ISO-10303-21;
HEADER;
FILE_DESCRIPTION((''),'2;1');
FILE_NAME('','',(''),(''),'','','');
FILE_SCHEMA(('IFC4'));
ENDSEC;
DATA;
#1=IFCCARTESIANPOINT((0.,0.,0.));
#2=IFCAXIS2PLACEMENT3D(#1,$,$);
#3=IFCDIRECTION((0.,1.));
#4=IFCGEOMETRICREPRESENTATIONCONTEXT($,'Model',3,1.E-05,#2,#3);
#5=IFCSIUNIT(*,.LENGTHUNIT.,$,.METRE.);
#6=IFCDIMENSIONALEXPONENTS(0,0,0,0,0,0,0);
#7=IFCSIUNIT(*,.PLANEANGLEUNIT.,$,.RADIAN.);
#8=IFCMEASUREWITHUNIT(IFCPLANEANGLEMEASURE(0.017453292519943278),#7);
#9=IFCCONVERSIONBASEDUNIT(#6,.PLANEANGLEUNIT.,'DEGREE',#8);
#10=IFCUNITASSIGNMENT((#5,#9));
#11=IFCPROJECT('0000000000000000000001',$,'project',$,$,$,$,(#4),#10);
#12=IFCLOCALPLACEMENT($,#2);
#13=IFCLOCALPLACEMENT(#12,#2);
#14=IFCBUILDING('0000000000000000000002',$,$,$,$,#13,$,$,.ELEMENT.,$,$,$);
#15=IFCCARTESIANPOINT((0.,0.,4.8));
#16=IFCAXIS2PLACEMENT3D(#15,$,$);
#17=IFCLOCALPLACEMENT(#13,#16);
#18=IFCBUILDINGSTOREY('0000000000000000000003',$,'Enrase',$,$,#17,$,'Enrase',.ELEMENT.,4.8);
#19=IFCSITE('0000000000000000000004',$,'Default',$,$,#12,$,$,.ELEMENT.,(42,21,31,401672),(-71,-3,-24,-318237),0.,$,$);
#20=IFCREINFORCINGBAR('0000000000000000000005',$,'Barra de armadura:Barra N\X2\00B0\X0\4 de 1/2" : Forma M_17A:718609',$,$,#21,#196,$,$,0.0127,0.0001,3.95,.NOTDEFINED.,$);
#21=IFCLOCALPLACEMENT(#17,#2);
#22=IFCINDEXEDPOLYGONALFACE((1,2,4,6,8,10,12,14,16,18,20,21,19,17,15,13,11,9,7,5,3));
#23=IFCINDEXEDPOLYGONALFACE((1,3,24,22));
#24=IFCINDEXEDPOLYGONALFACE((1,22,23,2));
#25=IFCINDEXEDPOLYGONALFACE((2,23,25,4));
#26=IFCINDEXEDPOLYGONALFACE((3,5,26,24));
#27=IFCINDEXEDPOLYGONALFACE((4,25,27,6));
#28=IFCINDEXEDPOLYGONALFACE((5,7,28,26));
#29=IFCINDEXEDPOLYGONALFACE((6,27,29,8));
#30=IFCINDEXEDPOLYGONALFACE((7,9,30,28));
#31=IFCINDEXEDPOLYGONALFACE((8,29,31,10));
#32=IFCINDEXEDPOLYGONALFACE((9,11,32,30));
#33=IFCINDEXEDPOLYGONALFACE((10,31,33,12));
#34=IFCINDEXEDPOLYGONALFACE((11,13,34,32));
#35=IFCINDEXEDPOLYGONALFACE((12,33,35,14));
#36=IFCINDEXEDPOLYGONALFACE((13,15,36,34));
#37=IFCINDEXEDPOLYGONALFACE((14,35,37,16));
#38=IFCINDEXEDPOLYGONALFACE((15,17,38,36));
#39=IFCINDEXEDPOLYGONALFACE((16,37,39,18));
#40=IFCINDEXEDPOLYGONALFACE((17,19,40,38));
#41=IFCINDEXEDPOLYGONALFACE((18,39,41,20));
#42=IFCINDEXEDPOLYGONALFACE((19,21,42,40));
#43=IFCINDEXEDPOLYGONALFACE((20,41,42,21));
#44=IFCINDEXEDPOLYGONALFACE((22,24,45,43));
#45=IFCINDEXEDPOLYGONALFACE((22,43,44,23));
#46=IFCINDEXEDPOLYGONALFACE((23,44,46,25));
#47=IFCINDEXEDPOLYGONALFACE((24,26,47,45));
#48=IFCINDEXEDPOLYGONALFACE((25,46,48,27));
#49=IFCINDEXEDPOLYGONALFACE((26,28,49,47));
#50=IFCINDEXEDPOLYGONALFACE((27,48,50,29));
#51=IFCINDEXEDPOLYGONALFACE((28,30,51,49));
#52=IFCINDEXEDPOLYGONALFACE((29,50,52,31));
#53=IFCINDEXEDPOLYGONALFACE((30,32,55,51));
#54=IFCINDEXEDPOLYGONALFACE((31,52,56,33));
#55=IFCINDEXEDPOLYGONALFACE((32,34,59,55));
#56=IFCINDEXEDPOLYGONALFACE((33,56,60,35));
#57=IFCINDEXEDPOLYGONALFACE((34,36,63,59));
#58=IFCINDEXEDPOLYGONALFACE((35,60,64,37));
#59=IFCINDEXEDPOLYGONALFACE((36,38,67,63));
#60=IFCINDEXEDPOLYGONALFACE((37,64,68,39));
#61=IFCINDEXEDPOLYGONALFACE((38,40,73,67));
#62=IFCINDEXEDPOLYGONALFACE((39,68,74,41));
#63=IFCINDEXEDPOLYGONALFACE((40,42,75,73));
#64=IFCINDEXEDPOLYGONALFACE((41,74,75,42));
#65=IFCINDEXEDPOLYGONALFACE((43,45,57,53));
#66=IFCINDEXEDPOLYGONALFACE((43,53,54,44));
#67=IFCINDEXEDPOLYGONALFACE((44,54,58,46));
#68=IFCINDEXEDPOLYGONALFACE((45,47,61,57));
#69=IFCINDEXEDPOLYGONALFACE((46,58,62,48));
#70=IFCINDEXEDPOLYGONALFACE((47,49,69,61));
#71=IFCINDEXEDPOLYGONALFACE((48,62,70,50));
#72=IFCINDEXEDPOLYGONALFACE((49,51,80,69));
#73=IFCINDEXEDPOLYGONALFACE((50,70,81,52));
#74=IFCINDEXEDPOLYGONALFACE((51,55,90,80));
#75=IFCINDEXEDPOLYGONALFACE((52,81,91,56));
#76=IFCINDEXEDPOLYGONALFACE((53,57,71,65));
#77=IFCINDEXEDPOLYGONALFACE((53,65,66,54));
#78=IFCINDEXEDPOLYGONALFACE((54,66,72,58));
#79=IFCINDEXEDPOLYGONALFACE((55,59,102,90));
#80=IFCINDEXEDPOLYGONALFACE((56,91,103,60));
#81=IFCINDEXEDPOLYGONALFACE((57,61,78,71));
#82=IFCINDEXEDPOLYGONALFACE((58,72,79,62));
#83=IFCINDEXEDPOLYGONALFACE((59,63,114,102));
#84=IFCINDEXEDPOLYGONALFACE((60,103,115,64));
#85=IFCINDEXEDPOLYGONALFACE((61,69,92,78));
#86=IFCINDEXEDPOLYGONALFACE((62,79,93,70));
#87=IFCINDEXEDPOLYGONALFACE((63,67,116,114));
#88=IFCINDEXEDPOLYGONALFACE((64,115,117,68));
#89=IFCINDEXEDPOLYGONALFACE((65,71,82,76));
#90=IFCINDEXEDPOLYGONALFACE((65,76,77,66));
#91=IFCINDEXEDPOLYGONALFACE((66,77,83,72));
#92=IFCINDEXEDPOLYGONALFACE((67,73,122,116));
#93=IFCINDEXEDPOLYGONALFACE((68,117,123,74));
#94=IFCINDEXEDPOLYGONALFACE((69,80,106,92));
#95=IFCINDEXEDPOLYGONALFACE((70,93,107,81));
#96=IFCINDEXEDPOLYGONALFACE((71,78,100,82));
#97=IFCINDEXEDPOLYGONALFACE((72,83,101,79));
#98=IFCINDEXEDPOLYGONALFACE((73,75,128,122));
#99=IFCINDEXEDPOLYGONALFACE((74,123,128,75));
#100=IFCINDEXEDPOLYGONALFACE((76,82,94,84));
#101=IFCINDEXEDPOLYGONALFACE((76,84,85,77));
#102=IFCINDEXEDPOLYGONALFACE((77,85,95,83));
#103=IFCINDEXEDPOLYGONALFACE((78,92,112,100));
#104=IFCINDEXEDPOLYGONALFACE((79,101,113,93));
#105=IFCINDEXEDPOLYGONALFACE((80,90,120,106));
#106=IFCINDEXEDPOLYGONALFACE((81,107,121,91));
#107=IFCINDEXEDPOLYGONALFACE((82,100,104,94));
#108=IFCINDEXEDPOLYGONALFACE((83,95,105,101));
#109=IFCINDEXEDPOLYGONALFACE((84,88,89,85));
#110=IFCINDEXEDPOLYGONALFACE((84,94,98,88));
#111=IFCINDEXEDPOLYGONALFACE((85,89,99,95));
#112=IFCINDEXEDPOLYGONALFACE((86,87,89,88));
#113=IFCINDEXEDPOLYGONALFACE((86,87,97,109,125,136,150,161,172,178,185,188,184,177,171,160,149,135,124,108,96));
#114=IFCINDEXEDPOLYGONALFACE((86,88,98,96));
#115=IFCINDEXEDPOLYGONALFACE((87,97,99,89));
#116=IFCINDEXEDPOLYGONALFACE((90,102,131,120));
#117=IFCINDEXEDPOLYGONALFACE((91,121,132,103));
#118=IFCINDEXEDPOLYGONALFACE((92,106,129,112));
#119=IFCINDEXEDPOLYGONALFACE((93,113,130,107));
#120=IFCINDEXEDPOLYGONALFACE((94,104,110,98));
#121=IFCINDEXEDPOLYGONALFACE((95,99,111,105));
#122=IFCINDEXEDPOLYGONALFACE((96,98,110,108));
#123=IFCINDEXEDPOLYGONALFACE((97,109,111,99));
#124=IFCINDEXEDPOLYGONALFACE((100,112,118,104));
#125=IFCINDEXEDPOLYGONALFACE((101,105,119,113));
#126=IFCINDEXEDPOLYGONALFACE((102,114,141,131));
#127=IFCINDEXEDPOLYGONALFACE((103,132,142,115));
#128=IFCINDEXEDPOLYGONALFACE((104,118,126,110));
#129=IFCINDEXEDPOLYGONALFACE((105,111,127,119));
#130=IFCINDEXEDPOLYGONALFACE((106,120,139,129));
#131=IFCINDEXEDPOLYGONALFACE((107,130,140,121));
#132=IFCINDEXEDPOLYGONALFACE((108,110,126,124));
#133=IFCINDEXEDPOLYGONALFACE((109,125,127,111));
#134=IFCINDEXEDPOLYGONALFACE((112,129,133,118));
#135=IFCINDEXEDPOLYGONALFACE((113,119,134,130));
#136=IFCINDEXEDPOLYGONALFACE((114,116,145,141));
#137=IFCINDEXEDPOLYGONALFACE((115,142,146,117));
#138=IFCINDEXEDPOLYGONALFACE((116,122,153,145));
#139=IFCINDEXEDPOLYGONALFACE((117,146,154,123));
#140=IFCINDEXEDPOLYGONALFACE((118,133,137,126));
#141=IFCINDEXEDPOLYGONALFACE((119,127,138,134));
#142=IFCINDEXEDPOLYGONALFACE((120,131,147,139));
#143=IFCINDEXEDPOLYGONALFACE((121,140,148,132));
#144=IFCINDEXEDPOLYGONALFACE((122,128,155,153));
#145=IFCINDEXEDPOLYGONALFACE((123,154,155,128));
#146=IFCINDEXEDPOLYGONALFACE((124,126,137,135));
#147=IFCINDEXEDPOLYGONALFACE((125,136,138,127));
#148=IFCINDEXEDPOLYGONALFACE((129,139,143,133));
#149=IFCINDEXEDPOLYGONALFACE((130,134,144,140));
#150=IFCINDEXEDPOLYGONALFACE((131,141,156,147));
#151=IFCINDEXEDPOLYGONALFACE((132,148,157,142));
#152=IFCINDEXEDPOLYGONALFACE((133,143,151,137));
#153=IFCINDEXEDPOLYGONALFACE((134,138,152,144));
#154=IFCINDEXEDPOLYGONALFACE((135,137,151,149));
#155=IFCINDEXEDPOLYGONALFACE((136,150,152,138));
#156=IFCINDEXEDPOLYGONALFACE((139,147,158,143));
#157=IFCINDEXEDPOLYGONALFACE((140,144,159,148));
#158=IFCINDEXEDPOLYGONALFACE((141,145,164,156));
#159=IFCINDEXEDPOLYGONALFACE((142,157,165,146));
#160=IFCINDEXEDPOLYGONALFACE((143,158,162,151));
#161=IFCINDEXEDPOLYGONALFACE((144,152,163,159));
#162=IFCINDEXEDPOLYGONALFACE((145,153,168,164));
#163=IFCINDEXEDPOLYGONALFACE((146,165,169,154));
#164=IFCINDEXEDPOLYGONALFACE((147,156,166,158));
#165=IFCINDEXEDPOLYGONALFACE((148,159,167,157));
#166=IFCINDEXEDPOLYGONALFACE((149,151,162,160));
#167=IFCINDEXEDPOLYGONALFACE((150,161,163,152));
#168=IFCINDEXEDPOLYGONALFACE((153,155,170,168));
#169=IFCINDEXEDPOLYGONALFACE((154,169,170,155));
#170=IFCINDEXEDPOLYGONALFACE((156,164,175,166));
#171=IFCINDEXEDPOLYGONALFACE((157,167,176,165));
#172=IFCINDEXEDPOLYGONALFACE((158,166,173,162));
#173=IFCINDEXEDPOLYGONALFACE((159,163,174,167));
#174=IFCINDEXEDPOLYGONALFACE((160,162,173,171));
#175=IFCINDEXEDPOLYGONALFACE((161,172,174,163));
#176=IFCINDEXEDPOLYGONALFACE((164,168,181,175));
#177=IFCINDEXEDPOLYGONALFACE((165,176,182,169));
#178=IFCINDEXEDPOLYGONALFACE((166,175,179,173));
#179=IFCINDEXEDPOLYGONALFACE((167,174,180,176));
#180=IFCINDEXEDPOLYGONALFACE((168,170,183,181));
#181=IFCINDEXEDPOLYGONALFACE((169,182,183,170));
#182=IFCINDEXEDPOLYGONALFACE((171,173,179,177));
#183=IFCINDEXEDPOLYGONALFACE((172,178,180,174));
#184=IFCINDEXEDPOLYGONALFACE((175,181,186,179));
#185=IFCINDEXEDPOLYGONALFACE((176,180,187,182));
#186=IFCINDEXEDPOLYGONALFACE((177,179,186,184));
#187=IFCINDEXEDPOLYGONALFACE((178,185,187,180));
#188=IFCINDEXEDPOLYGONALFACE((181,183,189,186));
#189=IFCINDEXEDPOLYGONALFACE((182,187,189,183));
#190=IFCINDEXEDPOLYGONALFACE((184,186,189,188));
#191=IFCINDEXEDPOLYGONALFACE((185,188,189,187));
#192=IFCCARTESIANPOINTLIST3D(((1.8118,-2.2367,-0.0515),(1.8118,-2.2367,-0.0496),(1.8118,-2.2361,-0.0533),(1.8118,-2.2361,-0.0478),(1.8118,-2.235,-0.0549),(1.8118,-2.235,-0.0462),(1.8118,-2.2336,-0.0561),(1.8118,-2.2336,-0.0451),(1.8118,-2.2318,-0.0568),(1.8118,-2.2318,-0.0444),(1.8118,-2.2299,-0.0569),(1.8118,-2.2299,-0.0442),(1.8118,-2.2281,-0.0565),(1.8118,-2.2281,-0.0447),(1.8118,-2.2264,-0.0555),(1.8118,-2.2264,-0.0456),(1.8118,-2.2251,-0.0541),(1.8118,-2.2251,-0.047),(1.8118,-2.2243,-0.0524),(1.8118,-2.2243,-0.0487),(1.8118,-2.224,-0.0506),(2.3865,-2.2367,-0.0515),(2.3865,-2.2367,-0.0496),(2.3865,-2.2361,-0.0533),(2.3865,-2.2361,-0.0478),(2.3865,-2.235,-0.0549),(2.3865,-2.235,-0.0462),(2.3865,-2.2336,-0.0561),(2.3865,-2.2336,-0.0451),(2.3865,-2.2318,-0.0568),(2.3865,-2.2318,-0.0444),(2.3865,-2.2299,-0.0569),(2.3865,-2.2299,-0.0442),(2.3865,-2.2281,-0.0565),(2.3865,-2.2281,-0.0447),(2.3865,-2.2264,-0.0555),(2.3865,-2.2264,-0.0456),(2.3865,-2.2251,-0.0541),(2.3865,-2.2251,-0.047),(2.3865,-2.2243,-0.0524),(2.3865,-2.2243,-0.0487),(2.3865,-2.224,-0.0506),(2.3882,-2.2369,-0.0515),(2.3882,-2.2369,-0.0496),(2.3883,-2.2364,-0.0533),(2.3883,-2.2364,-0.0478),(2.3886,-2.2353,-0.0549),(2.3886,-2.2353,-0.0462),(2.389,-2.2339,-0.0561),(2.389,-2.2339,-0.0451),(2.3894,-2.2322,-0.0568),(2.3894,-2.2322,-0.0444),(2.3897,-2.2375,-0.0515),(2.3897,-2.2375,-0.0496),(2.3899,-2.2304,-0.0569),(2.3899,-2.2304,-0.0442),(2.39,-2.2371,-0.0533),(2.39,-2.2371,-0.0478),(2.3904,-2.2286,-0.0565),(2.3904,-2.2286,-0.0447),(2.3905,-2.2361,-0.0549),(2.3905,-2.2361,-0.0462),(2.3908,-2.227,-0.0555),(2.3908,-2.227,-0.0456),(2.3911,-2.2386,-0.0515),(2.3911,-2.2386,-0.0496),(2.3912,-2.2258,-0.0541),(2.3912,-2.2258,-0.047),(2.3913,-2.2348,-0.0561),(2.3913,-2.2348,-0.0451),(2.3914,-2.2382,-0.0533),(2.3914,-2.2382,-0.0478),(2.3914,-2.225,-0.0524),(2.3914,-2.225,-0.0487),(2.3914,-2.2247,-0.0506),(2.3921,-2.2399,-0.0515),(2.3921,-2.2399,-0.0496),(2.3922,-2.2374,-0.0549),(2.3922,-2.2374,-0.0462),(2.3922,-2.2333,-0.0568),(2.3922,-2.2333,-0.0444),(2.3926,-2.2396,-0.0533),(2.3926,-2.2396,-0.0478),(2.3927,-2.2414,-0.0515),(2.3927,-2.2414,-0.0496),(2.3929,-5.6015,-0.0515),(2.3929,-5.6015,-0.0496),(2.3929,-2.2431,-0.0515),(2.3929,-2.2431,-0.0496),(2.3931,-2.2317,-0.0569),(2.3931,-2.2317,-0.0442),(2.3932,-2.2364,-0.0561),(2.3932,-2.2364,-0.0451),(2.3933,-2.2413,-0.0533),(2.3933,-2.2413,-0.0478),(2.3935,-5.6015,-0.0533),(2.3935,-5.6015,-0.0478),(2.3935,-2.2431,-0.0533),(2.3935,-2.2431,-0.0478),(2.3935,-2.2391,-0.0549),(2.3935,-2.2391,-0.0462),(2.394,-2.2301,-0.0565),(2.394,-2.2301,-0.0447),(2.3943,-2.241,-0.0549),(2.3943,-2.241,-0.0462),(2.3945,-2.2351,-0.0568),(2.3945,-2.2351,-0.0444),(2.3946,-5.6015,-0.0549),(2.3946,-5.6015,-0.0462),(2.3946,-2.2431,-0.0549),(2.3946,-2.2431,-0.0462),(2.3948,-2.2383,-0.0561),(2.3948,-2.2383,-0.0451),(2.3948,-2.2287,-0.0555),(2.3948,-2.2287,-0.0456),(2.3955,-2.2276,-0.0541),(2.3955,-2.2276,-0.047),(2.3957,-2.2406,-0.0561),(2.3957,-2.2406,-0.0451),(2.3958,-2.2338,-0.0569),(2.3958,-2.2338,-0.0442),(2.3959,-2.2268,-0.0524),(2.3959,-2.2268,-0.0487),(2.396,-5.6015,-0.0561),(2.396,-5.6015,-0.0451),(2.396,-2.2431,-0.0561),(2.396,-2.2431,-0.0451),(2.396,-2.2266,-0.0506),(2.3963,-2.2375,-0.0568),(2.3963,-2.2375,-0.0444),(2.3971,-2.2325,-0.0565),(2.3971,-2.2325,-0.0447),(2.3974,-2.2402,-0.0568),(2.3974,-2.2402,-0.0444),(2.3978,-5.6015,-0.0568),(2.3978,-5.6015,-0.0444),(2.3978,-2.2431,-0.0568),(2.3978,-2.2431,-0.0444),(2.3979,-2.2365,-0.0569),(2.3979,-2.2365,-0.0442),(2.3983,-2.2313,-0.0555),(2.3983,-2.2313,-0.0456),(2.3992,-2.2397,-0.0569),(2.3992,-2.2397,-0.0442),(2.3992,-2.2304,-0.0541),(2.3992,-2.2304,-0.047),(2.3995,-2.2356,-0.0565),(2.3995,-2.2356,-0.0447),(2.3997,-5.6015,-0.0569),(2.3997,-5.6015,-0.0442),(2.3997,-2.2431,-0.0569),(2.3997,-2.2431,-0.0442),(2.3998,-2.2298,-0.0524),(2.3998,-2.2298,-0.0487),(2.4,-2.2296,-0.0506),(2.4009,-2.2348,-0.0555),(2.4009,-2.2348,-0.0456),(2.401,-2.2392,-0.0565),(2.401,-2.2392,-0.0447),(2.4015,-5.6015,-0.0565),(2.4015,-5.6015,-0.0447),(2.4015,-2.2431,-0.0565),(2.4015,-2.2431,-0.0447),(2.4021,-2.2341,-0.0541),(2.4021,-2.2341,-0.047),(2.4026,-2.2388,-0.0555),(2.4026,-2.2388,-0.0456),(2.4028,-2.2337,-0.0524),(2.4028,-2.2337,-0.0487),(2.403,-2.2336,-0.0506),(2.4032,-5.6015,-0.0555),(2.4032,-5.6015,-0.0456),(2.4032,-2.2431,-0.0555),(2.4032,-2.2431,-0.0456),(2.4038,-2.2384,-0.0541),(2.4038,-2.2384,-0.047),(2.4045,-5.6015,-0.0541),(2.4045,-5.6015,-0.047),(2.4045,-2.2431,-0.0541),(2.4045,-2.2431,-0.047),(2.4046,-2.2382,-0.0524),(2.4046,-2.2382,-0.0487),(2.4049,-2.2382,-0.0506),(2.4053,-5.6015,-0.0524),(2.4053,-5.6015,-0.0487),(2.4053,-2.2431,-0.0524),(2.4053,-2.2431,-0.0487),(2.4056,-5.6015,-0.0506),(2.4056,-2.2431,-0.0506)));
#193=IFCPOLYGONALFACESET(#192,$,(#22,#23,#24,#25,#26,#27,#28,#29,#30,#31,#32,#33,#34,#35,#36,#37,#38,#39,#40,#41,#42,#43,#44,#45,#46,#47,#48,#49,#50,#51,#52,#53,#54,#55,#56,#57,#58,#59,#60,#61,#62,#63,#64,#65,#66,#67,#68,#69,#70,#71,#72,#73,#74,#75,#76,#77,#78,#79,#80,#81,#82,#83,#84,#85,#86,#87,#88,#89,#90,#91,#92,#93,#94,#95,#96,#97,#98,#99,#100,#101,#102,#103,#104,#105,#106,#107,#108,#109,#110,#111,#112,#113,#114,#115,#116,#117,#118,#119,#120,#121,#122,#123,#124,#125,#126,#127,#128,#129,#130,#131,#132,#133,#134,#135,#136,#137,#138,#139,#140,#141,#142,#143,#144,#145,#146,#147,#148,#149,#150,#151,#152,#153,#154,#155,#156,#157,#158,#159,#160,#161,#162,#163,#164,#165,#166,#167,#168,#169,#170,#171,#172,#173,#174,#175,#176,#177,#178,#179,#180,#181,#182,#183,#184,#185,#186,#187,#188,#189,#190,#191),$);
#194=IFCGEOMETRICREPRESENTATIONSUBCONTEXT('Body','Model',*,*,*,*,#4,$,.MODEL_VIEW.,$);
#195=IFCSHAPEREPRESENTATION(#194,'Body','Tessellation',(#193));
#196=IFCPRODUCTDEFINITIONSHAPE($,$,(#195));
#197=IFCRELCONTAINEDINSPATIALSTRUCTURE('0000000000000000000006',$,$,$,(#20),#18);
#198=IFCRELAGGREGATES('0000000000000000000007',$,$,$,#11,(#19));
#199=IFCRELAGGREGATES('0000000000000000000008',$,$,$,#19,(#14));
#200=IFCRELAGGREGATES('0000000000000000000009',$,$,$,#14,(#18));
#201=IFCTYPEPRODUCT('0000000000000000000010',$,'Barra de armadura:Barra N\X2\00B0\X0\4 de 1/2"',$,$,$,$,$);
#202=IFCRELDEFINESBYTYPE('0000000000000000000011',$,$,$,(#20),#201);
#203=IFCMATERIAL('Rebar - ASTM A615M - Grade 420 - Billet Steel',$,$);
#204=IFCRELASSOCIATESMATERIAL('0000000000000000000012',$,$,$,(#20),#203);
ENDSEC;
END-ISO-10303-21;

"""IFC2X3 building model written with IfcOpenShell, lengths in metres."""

from ifc_helpers import new_model, entity, si_unit, converted_unit, direction, frame, origin, place, context, subcontext, project, spatial, material, type_object, element, save


model = new_model("IFC2X3")

# Units and contexts
model_context = context("Model", 3, precision=1e-05, world=origin(), true_north=direction((0.0, 1.0)))
body_context = subcontext(model_context, "Body", "Model", "MODEL_VIEW")
ifc_project = project(units=[si_unit("LENGTHUNIT", "METRE"), converted_unit("PLANEANGLEUNIT", "DEGREE", entity("IfcPlaneAngleMeasure", 0.017453292519943278), si_unit("PLANEANGLEUNIT", "RADIAN"), dimensions=[0, 0, 0, 0, 0, 0, 0])], contexts=[model_context])

# Site, building, storey
site_placement = place(None, origin())
site = spatial("IfcSite", under=ifc_project, at=site_placement, Name="Default", CompositionType="ELEMENT", RefLatitude=(42, 21, 31, 401672), RefLongitude=(-71, -3, -24, -318237), RefElevation=0.0)
building_placement = place(site_placement, origin())
building = spatial("IfcBuilding", under=site, at=building_placement, CompositionType="ELEMENT")
storey_placement = place(building_placement, frame((0.0, 0.0, 4.8)))
storey = spatial("IfcBuildingStorey", under=building, at=storey_placement, Name="Enrase", LongName="Enrase", CompositionType="ELEMENT", Elevation=4.8)

# Reinforcing bar
ifc_material = material(Name="Rebar - ASTM A615M - Grade 420 - Billet Steel")
type_product_1 = type_object("IfcTypeProduct", Name="Barra de armadura:Barra N°4 de 1/2\"")
reinforcing_bar_1_placement = place(storey_placement, origin())
element("IfcReinforcingBar", 1, at=reinforcing_bar_1_placement, inside=storey, type_object=type_product_1, material=ifc_material, Name="Barra de armadura:Barra N°4 de 1/2\" : Forma M_17A:718609", BarLength=3.95, BarRole="NOTDEFINED", CrossSectionArea=0.0001, NominalDiameter=0.0127, context=body_context, shape_type="AdvancedSweptSolid", body=[
    entity("IfcSweptDiskSolid", entity("IfcCompositeCurve", [entity("IfcCompositeCurveSegment", "CONTINUOUS", True, entity("IfcPolyline", [entity("IfcCartesianPoint", [2.3992, -5.6015, -0.0506]), entity("IfcCartesianPoint", [2.3992, -2.2431, -0.0506])])), entity("IfcCompositeCurveSegment", "CONTINUOUS", True, entity("IfcTrimmedCurve", entity("IfcCircle", entity("IfcAxis2Placement3D", entity("IfcCartesianPoint", [2.3865, -2.2431, -0.0506]), entity("IfcDirection", [0.0, 0.0, 1.0]), entity("IfcDirection", [0.0, 1.0, 0.0])), 0.0127), [entity("IfcParameterValue", 270.0)], [entity("IfcParameterValue", 360.0)], True, "PARAMETER")), entity("IfcCompositeCurveSegment", "CONTINUOUS", True, entity("IfcPolyline", [entity("IfcCartesianPoint", [2.3865, -2.2304, -0.0506]), entity("IfcCartesianPoint", [1.8118, -2.2304, -0.0506])]))], False), 0.0063, None, 0.0, 92.0),
])

save(model, "model.ifc")
